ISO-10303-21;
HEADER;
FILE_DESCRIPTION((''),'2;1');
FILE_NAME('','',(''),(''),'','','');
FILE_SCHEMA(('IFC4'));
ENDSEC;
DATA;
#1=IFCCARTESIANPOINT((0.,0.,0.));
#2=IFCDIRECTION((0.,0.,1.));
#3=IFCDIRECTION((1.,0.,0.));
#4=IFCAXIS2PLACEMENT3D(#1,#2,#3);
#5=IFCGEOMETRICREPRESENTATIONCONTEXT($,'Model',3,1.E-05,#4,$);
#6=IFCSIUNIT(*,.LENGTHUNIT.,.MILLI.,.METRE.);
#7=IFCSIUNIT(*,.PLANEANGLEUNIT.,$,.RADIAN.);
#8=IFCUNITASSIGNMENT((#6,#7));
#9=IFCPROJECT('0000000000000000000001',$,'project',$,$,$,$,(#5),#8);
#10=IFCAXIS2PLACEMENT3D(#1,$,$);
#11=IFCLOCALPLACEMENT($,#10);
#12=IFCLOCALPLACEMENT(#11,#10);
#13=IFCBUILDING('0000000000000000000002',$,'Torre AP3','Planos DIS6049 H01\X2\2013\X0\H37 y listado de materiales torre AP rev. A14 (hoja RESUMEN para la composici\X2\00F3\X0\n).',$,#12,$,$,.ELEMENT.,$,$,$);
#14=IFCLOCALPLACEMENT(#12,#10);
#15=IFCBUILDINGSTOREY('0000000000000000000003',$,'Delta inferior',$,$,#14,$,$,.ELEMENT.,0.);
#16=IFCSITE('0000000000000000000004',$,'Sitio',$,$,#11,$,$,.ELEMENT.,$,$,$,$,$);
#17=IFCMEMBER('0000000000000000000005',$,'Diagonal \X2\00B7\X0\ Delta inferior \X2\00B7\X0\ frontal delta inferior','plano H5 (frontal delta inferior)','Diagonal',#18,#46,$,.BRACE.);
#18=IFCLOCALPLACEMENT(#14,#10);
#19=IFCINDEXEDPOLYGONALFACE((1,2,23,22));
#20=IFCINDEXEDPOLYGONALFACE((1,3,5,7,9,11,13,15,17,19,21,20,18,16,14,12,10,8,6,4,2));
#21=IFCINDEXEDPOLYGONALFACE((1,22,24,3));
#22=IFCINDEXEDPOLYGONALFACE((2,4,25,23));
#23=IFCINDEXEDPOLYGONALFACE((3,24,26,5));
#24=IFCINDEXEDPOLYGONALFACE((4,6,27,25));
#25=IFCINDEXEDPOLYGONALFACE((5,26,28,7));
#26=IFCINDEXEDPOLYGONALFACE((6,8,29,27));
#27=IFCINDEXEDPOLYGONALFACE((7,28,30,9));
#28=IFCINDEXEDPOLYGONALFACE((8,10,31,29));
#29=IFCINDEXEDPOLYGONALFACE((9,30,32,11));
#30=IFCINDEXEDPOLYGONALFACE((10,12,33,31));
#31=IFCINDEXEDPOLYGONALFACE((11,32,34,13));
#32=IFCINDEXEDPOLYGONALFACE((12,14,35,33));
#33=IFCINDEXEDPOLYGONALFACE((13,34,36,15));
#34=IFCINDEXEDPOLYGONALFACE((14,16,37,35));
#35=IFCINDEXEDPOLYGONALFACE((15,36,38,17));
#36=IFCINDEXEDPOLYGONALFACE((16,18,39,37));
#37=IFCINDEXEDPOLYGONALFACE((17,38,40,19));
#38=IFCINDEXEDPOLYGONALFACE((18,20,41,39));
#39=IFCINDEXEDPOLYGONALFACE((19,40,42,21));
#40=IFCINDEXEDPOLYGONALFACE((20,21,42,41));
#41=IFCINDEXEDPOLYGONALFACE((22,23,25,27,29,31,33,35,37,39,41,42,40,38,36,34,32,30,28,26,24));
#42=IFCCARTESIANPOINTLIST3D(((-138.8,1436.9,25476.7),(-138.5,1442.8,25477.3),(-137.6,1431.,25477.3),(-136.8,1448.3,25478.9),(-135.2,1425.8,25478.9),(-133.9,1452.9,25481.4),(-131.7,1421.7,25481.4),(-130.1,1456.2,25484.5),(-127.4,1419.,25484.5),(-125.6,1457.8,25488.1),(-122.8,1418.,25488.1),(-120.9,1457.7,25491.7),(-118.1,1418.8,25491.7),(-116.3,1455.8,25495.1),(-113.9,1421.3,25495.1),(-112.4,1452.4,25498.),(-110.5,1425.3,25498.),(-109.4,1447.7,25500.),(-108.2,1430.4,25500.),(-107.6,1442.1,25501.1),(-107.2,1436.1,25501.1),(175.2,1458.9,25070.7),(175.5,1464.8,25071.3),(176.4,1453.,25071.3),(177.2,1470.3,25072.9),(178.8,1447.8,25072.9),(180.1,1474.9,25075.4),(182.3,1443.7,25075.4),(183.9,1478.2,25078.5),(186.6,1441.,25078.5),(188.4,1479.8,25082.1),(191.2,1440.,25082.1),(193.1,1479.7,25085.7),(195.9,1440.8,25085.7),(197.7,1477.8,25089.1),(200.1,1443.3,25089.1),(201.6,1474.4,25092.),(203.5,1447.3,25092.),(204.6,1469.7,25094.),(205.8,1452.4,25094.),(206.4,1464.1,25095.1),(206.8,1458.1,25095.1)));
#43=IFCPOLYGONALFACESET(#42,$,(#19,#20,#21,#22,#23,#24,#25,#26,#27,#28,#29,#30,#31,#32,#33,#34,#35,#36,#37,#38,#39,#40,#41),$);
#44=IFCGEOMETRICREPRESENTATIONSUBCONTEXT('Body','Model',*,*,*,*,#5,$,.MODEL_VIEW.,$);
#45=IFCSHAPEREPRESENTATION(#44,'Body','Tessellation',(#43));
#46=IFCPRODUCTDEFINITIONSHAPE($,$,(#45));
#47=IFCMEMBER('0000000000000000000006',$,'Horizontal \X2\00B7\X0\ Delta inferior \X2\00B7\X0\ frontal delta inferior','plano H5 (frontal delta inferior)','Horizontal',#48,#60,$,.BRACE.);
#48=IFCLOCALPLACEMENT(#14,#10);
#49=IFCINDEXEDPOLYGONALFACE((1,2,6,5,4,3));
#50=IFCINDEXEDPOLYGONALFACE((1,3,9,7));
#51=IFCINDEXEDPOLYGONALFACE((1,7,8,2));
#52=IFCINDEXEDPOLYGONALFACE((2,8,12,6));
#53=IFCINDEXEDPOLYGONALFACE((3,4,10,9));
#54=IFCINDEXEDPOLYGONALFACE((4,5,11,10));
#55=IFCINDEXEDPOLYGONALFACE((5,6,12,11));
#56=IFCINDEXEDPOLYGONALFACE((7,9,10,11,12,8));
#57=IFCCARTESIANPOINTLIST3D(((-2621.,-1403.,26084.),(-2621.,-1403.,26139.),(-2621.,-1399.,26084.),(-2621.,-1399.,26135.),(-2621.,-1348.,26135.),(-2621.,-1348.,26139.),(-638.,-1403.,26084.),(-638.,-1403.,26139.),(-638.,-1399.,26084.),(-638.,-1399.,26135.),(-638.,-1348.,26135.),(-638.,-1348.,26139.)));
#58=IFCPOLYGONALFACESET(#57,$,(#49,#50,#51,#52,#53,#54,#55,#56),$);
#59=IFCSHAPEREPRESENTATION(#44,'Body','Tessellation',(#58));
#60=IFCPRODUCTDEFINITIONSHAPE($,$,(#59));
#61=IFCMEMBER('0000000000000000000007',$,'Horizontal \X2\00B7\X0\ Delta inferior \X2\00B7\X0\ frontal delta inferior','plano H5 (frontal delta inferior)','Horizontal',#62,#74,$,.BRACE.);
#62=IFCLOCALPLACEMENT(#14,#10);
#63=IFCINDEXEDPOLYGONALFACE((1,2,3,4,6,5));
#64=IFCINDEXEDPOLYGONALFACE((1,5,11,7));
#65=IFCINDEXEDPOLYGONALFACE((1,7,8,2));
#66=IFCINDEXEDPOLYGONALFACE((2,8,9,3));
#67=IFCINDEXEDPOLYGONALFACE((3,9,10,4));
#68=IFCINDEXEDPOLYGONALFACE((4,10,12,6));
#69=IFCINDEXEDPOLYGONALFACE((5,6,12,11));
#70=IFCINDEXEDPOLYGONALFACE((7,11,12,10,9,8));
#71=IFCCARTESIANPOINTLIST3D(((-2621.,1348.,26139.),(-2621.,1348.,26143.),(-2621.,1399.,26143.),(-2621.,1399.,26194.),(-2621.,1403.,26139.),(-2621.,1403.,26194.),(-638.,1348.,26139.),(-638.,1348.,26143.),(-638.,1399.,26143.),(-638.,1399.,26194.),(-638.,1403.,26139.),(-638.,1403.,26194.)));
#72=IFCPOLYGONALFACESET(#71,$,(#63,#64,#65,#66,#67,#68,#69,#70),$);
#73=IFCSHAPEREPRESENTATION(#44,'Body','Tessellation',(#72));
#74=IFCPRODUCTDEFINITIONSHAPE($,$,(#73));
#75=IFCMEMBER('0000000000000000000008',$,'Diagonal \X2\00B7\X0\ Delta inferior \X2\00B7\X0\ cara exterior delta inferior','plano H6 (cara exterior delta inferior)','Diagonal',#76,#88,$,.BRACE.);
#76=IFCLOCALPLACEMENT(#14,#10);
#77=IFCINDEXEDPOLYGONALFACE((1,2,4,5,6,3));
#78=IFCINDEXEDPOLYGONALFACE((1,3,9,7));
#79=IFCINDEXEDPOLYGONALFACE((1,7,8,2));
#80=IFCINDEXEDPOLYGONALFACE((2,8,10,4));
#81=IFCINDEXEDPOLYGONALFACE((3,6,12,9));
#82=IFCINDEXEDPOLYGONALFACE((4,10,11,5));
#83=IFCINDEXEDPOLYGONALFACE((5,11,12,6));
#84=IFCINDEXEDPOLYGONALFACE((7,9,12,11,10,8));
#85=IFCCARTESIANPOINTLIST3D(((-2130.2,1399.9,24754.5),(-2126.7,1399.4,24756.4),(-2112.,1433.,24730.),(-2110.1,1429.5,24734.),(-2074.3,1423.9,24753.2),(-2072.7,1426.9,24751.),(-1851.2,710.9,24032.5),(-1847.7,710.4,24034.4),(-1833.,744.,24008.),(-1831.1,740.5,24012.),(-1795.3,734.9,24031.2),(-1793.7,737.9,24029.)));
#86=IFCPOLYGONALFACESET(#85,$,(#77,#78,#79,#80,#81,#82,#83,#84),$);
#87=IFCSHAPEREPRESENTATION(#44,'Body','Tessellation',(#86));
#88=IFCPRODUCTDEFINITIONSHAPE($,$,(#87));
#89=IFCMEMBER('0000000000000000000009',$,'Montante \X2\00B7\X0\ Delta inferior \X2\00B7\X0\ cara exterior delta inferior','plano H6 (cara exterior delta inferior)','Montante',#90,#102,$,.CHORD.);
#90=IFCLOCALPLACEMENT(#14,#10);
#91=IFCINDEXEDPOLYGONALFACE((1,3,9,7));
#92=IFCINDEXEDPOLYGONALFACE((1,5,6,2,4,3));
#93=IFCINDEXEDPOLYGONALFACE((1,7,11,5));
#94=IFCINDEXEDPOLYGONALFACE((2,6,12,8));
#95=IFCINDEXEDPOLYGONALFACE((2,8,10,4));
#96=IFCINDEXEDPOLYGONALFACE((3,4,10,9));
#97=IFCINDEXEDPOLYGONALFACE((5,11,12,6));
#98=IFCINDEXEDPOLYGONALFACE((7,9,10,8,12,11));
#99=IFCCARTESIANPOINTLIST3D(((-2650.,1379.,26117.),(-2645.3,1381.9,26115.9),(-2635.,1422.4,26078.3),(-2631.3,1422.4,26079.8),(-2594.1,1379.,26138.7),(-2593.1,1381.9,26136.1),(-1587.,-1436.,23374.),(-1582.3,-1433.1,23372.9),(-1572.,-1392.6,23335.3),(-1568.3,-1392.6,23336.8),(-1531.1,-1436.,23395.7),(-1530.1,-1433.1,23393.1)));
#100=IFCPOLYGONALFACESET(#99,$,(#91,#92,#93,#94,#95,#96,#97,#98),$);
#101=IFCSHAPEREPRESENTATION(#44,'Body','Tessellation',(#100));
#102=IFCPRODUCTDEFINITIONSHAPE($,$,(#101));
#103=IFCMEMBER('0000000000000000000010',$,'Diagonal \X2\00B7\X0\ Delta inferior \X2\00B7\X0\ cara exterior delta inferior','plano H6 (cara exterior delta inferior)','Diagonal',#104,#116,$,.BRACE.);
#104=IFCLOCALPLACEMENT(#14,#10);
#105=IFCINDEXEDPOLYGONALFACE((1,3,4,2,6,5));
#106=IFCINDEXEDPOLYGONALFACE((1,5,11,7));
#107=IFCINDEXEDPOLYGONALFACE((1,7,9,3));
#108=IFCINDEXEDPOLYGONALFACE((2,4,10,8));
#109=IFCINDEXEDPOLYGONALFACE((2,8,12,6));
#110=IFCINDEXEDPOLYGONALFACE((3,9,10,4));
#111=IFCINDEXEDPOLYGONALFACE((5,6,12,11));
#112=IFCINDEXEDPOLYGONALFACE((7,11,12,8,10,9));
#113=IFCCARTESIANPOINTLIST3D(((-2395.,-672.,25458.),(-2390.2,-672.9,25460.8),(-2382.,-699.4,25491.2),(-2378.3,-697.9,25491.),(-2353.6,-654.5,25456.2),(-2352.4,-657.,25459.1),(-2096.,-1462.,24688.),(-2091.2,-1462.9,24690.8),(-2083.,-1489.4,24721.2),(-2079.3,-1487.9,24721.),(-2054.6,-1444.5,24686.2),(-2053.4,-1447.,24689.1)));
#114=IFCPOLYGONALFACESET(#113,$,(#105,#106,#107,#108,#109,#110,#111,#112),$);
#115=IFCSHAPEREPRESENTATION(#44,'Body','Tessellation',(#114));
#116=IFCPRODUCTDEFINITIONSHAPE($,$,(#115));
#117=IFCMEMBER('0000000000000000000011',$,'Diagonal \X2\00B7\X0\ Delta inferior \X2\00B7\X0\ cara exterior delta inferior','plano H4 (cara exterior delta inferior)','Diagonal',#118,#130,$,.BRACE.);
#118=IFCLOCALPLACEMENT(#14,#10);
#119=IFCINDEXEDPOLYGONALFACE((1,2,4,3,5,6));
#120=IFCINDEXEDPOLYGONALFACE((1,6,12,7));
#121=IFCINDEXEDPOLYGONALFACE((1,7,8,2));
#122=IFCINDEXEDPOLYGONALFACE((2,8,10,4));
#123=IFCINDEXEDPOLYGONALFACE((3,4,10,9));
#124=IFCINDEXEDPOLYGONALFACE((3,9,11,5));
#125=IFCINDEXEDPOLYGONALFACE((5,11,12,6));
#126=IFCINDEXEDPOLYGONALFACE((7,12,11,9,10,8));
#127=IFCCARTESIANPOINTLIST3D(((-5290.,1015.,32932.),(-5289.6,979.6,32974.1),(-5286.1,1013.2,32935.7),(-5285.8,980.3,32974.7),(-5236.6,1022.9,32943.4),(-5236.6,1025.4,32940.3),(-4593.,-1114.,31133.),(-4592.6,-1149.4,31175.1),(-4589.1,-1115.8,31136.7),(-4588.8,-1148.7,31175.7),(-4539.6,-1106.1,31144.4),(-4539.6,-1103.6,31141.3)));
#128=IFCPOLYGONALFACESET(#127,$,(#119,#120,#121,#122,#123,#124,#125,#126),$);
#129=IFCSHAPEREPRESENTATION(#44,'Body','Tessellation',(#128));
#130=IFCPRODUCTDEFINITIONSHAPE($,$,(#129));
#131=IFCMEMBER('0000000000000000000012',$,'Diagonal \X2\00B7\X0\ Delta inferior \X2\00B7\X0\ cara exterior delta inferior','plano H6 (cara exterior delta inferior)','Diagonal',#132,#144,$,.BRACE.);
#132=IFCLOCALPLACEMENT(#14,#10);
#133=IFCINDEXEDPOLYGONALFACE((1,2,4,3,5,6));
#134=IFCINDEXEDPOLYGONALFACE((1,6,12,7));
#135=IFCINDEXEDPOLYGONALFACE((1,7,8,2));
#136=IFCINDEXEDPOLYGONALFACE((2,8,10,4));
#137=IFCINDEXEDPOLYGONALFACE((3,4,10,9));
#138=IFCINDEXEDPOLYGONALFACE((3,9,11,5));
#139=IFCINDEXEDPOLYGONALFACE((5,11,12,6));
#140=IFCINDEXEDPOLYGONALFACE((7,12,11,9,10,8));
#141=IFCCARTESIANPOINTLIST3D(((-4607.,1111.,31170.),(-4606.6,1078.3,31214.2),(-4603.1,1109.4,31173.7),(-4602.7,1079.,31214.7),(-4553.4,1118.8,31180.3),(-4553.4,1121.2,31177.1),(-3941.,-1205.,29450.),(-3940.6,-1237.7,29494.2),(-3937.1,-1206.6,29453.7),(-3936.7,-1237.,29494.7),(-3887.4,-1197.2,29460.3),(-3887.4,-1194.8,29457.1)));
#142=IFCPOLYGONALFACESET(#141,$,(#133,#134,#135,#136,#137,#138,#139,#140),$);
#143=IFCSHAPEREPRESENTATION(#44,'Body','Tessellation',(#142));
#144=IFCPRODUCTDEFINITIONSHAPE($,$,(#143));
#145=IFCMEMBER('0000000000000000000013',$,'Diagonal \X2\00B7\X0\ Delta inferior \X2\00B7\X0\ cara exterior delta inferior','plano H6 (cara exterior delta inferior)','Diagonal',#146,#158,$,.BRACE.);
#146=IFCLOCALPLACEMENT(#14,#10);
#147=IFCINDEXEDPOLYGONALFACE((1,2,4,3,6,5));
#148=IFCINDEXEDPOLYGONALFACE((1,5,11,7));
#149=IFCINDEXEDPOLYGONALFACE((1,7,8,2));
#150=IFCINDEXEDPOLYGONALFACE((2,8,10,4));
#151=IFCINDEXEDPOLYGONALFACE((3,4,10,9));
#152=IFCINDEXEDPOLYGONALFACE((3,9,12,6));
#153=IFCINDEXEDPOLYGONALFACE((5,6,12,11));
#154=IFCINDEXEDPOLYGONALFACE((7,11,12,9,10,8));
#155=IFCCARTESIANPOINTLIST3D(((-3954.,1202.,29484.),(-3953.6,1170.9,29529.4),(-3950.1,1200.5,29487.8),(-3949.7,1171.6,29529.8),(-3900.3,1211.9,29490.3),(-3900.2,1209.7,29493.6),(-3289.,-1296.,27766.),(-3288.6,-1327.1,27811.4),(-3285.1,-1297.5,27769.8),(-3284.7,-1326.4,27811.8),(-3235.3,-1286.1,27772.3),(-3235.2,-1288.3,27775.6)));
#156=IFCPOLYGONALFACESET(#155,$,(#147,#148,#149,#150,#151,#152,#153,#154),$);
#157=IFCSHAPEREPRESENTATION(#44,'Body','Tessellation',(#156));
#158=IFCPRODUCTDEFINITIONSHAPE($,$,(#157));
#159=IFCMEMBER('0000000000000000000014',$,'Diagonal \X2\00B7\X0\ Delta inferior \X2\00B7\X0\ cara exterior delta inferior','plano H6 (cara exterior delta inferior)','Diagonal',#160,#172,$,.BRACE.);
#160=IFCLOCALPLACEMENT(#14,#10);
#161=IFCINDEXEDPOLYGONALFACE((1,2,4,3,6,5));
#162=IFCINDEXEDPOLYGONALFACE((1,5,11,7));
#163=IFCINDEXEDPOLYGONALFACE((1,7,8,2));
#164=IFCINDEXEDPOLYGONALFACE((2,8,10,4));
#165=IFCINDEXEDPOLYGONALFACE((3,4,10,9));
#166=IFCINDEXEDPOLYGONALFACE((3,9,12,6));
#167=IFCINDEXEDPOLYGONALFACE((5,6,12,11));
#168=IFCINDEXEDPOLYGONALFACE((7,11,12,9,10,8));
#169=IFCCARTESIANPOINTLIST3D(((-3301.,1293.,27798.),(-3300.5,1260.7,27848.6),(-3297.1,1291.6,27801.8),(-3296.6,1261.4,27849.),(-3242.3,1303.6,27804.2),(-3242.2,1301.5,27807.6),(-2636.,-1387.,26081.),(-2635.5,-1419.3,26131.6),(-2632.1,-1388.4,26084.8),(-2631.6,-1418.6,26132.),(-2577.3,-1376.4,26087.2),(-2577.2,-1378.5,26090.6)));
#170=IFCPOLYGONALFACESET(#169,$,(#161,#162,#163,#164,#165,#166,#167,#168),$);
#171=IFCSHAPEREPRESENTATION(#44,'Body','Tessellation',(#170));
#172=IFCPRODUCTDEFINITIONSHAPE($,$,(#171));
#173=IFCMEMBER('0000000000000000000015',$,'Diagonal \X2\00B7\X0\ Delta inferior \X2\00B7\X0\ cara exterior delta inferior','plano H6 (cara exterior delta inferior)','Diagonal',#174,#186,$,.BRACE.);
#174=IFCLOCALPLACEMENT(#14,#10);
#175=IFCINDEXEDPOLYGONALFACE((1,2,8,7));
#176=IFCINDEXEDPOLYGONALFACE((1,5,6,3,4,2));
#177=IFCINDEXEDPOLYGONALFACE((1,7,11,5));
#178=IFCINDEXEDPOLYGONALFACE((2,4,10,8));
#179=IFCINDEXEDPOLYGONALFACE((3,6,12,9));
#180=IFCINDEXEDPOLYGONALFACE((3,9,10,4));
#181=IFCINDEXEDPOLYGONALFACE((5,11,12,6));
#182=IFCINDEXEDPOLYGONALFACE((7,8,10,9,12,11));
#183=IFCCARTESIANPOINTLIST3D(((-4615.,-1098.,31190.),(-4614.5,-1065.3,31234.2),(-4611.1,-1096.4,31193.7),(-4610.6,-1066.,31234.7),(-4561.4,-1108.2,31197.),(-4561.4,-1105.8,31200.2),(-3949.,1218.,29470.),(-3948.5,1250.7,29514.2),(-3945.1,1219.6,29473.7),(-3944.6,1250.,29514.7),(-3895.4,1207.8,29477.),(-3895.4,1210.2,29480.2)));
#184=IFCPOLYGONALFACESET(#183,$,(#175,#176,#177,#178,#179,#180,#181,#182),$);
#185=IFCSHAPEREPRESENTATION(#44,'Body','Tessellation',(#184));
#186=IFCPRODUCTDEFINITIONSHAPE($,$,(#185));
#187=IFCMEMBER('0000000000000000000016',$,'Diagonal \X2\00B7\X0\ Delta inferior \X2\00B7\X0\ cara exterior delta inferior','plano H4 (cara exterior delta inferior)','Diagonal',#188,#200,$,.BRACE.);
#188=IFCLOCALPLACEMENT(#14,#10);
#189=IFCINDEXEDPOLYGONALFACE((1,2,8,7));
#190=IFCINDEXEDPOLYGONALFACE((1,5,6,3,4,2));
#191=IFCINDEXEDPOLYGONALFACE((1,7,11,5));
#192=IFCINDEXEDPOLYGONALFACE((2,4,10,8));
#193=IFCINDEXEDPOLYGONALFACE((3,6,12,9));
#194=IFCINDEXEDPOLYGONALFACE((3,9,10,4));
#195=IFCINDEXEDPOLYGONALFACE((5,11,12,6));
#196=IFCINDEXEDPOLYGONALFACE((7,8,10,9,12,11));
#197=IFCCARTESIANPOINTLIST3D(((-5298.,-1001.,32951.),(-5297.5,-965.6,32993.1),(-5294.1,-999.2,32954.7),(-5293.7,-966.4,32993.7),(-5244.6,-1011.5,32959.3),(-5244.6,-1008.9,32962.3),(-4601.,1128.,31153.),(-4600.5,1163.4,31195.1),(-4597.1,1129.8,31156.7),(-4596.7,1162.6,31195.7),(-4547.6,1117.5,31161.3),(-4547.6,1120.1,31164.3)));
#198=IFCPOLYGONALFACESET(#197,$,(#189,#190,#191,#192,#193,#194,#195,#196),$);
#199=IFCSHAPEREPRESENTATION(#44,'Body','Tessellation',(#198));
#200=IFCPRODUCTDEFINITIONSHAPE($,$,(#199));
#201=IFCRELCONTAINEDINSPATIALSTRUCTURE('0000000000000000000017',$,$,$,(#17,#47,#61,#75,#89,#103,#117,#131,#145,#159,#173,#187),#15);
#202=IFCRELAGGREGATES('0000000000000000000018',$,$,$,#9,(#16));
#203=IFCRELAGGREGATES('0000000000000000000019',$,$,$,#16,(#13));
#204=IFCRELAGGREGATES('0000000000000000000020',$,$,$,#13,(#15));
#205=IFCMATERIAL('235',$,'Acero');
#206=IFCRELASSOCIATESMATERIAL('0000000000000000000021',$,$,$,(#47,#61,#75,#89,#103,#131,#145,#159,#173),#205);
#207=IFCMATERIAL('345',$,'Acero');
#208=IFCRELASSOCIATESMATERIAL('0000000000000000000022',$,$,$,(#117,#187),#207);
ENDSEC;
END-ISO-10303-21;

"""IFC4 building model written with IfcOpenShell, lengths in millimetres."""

from ifc_helpers import new_model, si_unit, frame, frame_2d, origin, origin_with_axes, place, context, subcontext, project, spatial, circle, l_section, extrude, material, element, save


model = new_model("IFC4")

# Units and contexts
model_context = context("Model", 3, precision=1e-05, world=origin_with_axes())
body_context = subcontext(model_context, "Body", "Model", "MODEL_VIEW")
ifc_project = project(units=[si_unit("LENGTHUNIT", "METRE", prefix="MILLI"), si_unit("PLANEANGLEUNIT", "RADIAN")], contexts=[model_context])

# Site, building, storey
site_placement = place(None, origin())
site = spatial("IfcSite", under=ifc_project, at=site_placement, Name="Sitio", CompositionType="ELEMENT")
building_placement = place(site_placement, origin())
building = spatial("IfcBuilding", under=site, at=building_placement, Name="Torre AP3", Description="Planos DIS6049 H01–H37 y listado de materiales torre AP rev. A14 (hoja RESUMEN para la composición).", CompositionType="ELEMENT")
storey_placement = place(building_placement, origin())
storey = spatial("IfcBuildingStorey", under=building, at=storey_placement, Name="Delta inferior", CompositionType="ELEMENT", Elevation=0.0)

# Members
ifc_material_1 = material(Name="235", Category="Acero")
for number, where, z_axis, x_axis, name in (
    (1, (191.0, 1460.0, 25083.0), (-0.611219, -0.042824, 0.790302), (0.011492, -0.99891, -0.04524), "Diagonal · Delta inferior · frontal delta inferior"),
):
    element("IfcMember", number, at=place(storey_placement, frame(where, z_axis=z_axis, x_axis=x_axis)), inside=storey, Name=name, Description="plano H5 (frontal delta inferior)", ObjectType="Diagonal", PredefinedType="BRACE", context=body_context, shape_type="SweptSolid", body=[
        extrude(circle(Radius=20.0), None, (0.0, 0.0, 1.0), 513.7),
    ])
for number, where, z_axis, x_axis, name in (
    (2, (-638.0, -1403.0, 26139.0), (-1.0, 0.0, 0.0), (0.0, 1.0, 0.0), "Horizontal · Delta inferior · frontal delta inferior"),
    (3, (-638.0, 1403.0, 26139.0), (-1.0, 0.0, 0.0), (0.0, -1.0, 0.0), "Horizontal · Delta inferior · frontal delta inferior"),
):
    element("IfcMember", number, at=place(storey_placement, frame(where, z_axis=z_axis, x_axis=x_axis)), inside=storey, material=ifc_material_1, Name=name, Description="plano H5 (frontal delta inferior)", ObjectType="Horizontal", PredefinedType="BRACE", context=body_context, shape_type="SweptSolid", body=[
        extrude(l_section(Depth=55.0, Width=55.0, Thickness=4.0, at=frame_2d((27.5, 27.5))), None, (0.0, 0.0, 1.0), 1983.0),
    ])
member_1_placement = place(storey_placement, frame((-2112.0, 1433.0, 24730.0), z_axis=(0.269236, -0.664888, -0.696733), x_axis=(0.873631, -0.135855, 0.46724)))
element("IfcMember", 4, at=member_1_placement, inside=storey, material=ifc_material_1, Name="Diagonal · Delta inferior · cara exterior delta inferior", Description="plano H6 (cara exterior delta inferior)", ObjectType="Diagonal", PredefinedType="BRACE", context=body_context, shape_type="SweptSolid", body=[
    extrude(l_section(Depth=45.0, Width=45.0, Thickness=4.0, at=frame_2d((22.5, 22.5))), None, (0.0, 0.0, 1.0), 1036.3),
])
member_2_placement = place(storey_placement, frame((-2650.0, 1379.0, 26117.0), z_axis=(0.261074, -0.691368, -0.673685), x_axis=(0.249824, 0.722503, -0.644653)))
element("IfcMember", 5, at=member_2_placement, inside=storey, material=ifc_material_1, Name="Montante · Delta inferior · cara exterior delta inferior", Description="plano H6 (cara exterior delta inferior)", ObjectType="Montante", PredefinedType="CHORD", context=body_context, shape_type="SweptSolid", body=[
    extrude(l_section(Depth=60.0, Width=60.0, Thickness=4.0, at=frame_2d((30.0, 30.0))), None, (0.0, 0.0, 1.0), 4071.6),
])
member_3_placement = place(storey_placement, frame((-2395.0, -672.0, 25458.0), z_axis=(0.261597, -0.691176, -0.673678), x_axis=(0.920687, 0.38817, -0.040739)))
element("IfcMember", 6, at=member_3_placement, inside=storey, material=ifc_material_1, Name="Diagonal · Delta inferior · cara exterior delta inferior", Description="plano H6 (cara exterior delta inferior)", ObjectType="Diagonal", PredefinedType="BRACE", context=body_context, shape_type="SweptSolid", body=[
    extrude(l_section(Depth=45.0, Width=45.0, Thickness=4.0, at=frame_2d((22.5, 22.5))), None, (0.0, 0.0, 1.0), 1143.0),
])
ifc_material_2 = material(Name="345", Category="Acero")
member_4_placement = place(storey_placement, frame((-5290.0, 1015.0, 32932.0), z_axis=(0.242593, -0.741005, -0.626147), x_axis=(0.970107, 0.189587, 0.151492)))
element("IfcMember", 7, at=member_4_placement, inside=storey, material=ifc_material_2, Name="Diagonal · Delta inferior · cara exterior delta inferior", Description="plano H4 (cara exterior delta inferior)", ObjectType="Diagonal", PredefinedType="BRACE", context=body_context, shape_type="SweptSolid", body=[
    extrude(l_section(Depth=55.0, Width=55.0, Thickness=4.0, at=frame_2d((27.5, 27.5))), None, (0.0, 0.0, 1.0), 2873.1),
])
member_5_placement = place(storey_placement, frame((-4607.0, 1111.0, 31170.0), z_axis=(0.224946, -0.782244, -0.580941), x_axis=(0.974349, 0.184591, 0.128724)))
element("IfcMember", 8, at=member_5_placement, inside=storey, material=ifc_material_1, Name="Diagonal · Delta inferior · cara exterior delta inferior", Description="plano H6 (cara exterior delta inferior)", ObjectType="Diagonal", PredefinedType="BRACE", context=body_context, shape_type="SweptSolid", body=[
    extrude(l_section(Depth=55.0, Width=55.0, Thickness=4.0, at=frame_2d((27.5, 27.5))), None, (0.0, 0.0, 1.0), 2960.7),
])
member_6_placement = place(storey_placement, frame((-3954.0, 1202.0, 29484.0), z_axis=(0.214252, -0.804812, -0.55351), x_axis=(0.976751, 0.180783, 0.115217)))
element("IfcMember", 9, at=member_6_placement, inside=storey, material=ifc_material_1, Name="Diagonal · Delta inferior · cara exterior delta inferior", Description="plano H6 (cara exterior delta inferior)", ObjectType="Diagonal", PredefinedType="BRACE", context=body_context, shape_type="SweptSolid", body=[
    extrude(l_section(Depth=55.0, Width=55.0, Thickness=4.0, at=frame_2d((27.5, 27.5))), None, (0.0, 0.0, 1.0), 3103.8),
])
member_7_placement = place(storey_placement, frame((-3301.0, 1293.0, 27798.0), z_axis=(0.204517, -0.824217, -0.528052), x_axis=(0.978826, 0.176893, 0.102997)))
element("IfcMember", 10, at=member_7_placement, inside=storey, material=ifc_material_1, Name="Diagonal · Delta inferior · cara exterior delta inferior", Description="plano H6 (cara exterior delta inferior)", ObjectType="Diagonal", PredefinedType="BRACE", context=body_context, shape_type="SweptSolid", body=[
    extrude(l_section(Depth=60.0, Width=60.0, Thickness=4.0, at=frame_2d((30.0, 30.0))), None, (0.0, 0.0, 1.0), 3251.6),
])
member_8_placement = place(storey_placement, frame((-3949.0, 1218.0, 29470.0), z_axis=(-0.224946, -0.782244, 0.580941), x_axis=(0.974336, -0.185683, 0.127247)))
element("IfcMember", 11, at=member_8_placement, inside=storey, material=ifc_material_1, Name="Diagonal · Delta inferior · cara exterior delta inferior", Description="plano H6 (cara exterior delta inferior)", ObjectType="Diagonal", PredefinedType="BRACE", context=body_context, shape_type="SweptSolid", body=[
    extrude(l_section(Depth=55.0, Width=55.0, Thickness=4.0, at=frame_2d((27.5, 27.5))), None, (0.0, 0.0, 1.0), 2960.7),
])
member_9_placement = place(storey_placement, frame((-4601.0, 1128.0, 31153.0), z_axis=(-0.242646, -0.741166, 0.625936), x_axis=(0.97008, -0.190866, 0.150051)))
element("IfcMember", 12, at=member_9_placement, inside=storey, material=ifc_material_2, Name="Diagonal · Delta inferior · cara exterior delta inferior", Description="plano H4 (cara exterior delta inferior)", ObjectType="Diagonal", PredefinedType="BRACE", context=body_context, shape_type="SweptSolid", body=[
    extrude(l_section(Depth=55.0, Width=55.0, Thickness=4.0, at=frame_2d((27.5, 27.5))), None, (0.0, 0.0, 1.0), 2872.5),
])

save(model, "model.ifc")
